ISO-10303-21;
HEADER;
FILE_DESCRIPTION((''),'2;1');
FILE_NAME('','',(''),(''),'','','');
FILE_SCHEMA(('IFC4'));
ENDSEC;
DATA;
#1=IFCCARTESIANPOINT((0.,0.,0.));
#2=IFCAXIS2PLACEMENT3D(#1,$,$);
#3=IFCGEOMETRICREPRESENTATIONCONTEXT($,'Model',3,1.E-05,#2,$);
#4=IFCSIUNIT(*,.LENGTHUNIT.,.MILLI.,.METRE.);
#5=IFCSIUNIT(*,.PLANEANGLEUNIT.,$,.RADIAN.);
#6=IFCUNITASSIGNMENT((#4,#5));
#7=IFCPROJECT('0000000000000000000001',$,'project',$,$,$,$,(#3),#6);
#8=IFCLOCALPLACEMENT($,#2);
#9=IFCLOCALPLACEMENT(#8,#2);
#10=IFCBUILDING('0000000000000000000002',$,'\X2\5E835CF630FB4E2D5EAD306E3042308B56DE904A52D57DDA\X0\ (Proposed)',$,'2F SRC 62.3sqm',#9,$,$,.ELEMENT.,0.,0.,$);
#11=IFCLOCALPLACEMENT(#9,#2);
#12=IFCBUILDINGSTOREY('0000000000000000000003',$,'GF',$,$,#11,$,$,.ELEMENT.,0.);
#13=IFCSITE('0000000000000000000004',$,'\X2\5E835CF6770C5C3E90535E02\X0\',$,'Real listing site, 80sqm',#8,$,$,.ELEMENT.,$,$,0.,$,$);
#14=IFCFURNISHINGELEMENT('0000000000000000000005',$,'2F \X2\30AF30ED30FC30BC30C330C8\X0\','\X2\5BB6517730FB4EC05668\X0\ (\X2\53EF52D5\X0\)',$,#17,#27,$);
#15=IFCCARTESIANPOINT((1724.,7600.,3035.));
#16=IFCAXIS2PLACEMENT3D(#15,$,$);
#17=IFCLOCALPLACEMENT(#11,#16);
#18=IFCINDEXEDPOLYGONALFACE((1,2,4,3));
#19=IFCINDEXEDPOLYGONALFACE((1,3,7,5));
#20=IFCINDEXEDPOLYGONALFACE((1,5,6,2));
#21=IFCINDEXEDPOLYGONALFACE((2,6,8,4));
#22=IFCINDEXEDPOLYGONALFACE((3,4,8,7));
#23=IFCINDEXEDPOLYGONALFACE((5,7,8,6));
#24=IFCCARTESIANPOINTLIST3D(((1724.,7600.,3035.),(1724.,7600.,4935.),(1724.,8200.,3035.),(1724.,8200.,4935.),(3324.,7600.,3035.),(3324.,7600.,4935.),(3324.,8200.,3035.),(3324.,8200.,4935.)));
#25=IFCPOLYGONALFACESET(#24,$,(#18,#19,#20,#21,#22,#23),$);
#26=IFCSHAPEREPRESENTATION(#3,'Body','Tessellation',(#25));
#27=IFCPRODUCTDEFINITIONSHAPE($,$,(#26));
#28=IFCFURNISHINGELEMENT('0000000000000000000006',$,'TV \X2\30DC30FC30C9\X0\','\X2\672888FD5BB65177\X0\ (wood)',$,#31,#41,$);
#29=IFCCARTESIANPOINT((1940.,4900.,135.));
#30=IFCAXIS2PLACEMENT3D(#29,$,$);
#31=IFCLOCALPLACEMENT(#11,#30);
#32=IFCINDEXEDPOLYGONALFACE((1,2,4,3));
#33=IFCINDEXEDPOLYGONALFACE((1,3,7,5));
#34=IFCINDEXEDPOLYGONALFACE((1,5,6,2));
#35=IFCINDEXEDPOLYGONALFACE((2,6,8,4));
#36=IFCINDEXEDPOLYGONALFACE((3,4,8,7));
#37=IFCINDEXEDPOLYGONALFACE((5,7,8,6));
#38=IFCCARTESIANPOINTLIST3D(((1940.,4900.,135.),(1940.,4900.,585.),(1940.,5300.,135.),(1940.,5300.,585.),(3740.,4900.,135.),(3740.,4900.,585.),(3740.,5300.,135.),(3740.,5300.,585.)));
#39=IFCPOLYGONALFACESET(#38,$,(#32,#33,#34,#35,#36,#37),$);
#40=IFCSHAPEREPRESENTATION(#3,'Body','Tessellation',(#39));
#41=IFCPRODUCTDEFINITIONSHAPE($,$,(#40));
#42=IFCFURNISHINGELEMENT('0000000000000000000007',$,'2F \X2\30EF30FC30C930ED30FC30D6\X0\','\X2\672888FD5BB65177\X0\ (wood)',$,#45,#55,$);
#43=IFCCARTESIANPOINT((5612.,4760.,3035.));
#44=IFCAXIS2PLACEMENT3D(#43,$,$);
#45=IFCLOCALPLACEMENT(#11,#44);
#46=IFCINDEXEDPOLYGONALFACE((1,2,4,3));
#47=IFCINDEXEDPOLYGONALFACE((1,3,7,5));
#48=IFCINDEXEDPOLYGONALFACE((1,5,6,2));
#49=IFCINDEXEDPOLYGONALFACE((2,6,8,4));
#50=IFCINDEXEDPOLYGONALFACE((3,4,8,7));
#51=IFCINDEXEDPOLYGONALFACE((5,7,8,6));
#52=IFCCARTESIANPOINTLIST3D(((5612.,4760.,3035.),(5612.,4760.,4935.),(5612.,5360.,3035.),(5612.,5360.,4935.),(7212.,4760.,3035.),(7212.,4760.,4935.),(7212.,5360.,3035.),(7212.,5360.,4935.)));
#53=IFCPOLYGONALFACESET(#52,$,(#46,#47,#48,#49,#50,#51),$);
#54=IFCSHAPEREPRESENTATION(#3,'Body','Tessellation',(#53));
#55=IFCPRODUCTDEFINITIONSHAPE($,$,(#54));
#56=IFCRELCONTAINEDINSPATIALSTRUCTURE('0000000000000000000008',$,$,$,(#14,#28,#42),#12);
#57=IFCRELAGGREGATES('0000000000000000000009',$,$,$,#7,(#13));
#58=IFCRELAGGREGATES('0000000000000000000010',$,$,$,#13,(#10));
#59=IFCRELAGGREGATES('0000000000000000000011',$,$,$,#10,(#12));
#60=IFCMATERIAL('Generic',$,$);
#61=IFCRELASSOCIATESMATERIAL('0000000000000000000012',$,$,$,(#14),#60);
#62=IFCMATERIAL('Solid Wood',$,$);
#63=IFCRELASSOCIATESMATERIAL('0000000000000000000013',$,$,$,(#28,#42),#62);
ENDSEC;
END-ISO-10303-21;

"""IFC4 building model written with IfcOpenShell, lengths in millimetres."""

from ifc_helpers import new_model, si_unit, frame, frame_2d, origin, place, context, project, spatial, rectangle, extrude, material, element, save


model = new_model("IFC4")

# Units and contexts
model_context = context("Model", 3, precision=1e-05, world=origin())
ifc_project = project(units=[si_unit("LENGTHUNIT", "METRE", prefix="MILLI"), si_unit("PLANEANGLEUNIT", "RADIAN")], contexts=[model_context])

# Site, building, storey
site_placement = place(None, origin())
site = spatial("IfcSite", under=ifc_project, at=site_placement, Name="広島県尾道市", ObjectType="Real listing site, 80sqm", CompositionType="ELEMENT", RefElevation=0.0)
building_placement = place(site_placement, origin())
building = spatial("IfcBuilding", under=site, at=building_placement, Name="広島・中庭のある回遊動線 (Proposed)", ObjectType="2F SRC 62.3sqm", CompositionType="ELEMENT", ElevationOfRefHeight=0.0, ElevationOfTerrain=0.0)
storey_placement = place(building_placement, origin())
storey = spatial("IfcBuildingStorey", under=building, at=storey_placement, Name="GF", CompositionType="ELEMENT", Elevation=0.0)

# Shared definitions
ifc_material_1 = material(Name="Solid Wood")

# Shared definitions
ifc_material_2 = material(Name="Generic")

# Furnishing elements
furnishing_1_placement = place(storey_placement, frame((1724.0, 7600.0, 3035.0)))
element("IfcFurnishingElement", 1, at=furnishing_1_placement, inside=storey, material=ifc_material_2, Name="2F クローゼット", Description="家具・什器 (可動)", context=model_context, shape_type="SweptSolid", body=[
    extrude(rectangle(XDim=1600.0, YDim=600.0, at=frame_2d((800.0, 300.0))), frame((1724.0, 7600.0, 3035.0)), (0.0, 0.0, 1.0), 1900.0),
])
furnishing_2_placement = place(storey_placement, frame((1940.0, 4900.0, 135.0)))
element("IfcFurnishingElement", 2, at=furnishing_2_placement, inside=storey, material=ifc_material_1, Name="TV ボード", Description="木製家具 (wood)", context=model_context, shape_type="SweptSolid", body=[
    extrude(rectangle(XDim=1800.0, YDim=400.0, at=frame_2d((900.0, 200.0))), frame((1940.0, 4900.0, 135.0)), (0.0, 0.0, 1.0), 450.0),
])
furnishing_3_placement = place(storey_placement, frame((5612.0, 4760.0, 3035.0)))
element("IfcFurnishingElement", 3, at=furnishing_3_placement, inside=storey, material=ifc_material_1, Name="2F ワードローブ", Description="木製家具 (wood)", context=model_context, shape_type="SweptSolid", body=[
    extrude(rectangle(XDim=1600.0, YDim=600.0, at=frame_2d((800.0, 300.0))), frame((5612.0, 4760.0, 3035.0)), (0.0, 0.0, 1.0), 1900.0),
])

save(model, "model.ifc")
